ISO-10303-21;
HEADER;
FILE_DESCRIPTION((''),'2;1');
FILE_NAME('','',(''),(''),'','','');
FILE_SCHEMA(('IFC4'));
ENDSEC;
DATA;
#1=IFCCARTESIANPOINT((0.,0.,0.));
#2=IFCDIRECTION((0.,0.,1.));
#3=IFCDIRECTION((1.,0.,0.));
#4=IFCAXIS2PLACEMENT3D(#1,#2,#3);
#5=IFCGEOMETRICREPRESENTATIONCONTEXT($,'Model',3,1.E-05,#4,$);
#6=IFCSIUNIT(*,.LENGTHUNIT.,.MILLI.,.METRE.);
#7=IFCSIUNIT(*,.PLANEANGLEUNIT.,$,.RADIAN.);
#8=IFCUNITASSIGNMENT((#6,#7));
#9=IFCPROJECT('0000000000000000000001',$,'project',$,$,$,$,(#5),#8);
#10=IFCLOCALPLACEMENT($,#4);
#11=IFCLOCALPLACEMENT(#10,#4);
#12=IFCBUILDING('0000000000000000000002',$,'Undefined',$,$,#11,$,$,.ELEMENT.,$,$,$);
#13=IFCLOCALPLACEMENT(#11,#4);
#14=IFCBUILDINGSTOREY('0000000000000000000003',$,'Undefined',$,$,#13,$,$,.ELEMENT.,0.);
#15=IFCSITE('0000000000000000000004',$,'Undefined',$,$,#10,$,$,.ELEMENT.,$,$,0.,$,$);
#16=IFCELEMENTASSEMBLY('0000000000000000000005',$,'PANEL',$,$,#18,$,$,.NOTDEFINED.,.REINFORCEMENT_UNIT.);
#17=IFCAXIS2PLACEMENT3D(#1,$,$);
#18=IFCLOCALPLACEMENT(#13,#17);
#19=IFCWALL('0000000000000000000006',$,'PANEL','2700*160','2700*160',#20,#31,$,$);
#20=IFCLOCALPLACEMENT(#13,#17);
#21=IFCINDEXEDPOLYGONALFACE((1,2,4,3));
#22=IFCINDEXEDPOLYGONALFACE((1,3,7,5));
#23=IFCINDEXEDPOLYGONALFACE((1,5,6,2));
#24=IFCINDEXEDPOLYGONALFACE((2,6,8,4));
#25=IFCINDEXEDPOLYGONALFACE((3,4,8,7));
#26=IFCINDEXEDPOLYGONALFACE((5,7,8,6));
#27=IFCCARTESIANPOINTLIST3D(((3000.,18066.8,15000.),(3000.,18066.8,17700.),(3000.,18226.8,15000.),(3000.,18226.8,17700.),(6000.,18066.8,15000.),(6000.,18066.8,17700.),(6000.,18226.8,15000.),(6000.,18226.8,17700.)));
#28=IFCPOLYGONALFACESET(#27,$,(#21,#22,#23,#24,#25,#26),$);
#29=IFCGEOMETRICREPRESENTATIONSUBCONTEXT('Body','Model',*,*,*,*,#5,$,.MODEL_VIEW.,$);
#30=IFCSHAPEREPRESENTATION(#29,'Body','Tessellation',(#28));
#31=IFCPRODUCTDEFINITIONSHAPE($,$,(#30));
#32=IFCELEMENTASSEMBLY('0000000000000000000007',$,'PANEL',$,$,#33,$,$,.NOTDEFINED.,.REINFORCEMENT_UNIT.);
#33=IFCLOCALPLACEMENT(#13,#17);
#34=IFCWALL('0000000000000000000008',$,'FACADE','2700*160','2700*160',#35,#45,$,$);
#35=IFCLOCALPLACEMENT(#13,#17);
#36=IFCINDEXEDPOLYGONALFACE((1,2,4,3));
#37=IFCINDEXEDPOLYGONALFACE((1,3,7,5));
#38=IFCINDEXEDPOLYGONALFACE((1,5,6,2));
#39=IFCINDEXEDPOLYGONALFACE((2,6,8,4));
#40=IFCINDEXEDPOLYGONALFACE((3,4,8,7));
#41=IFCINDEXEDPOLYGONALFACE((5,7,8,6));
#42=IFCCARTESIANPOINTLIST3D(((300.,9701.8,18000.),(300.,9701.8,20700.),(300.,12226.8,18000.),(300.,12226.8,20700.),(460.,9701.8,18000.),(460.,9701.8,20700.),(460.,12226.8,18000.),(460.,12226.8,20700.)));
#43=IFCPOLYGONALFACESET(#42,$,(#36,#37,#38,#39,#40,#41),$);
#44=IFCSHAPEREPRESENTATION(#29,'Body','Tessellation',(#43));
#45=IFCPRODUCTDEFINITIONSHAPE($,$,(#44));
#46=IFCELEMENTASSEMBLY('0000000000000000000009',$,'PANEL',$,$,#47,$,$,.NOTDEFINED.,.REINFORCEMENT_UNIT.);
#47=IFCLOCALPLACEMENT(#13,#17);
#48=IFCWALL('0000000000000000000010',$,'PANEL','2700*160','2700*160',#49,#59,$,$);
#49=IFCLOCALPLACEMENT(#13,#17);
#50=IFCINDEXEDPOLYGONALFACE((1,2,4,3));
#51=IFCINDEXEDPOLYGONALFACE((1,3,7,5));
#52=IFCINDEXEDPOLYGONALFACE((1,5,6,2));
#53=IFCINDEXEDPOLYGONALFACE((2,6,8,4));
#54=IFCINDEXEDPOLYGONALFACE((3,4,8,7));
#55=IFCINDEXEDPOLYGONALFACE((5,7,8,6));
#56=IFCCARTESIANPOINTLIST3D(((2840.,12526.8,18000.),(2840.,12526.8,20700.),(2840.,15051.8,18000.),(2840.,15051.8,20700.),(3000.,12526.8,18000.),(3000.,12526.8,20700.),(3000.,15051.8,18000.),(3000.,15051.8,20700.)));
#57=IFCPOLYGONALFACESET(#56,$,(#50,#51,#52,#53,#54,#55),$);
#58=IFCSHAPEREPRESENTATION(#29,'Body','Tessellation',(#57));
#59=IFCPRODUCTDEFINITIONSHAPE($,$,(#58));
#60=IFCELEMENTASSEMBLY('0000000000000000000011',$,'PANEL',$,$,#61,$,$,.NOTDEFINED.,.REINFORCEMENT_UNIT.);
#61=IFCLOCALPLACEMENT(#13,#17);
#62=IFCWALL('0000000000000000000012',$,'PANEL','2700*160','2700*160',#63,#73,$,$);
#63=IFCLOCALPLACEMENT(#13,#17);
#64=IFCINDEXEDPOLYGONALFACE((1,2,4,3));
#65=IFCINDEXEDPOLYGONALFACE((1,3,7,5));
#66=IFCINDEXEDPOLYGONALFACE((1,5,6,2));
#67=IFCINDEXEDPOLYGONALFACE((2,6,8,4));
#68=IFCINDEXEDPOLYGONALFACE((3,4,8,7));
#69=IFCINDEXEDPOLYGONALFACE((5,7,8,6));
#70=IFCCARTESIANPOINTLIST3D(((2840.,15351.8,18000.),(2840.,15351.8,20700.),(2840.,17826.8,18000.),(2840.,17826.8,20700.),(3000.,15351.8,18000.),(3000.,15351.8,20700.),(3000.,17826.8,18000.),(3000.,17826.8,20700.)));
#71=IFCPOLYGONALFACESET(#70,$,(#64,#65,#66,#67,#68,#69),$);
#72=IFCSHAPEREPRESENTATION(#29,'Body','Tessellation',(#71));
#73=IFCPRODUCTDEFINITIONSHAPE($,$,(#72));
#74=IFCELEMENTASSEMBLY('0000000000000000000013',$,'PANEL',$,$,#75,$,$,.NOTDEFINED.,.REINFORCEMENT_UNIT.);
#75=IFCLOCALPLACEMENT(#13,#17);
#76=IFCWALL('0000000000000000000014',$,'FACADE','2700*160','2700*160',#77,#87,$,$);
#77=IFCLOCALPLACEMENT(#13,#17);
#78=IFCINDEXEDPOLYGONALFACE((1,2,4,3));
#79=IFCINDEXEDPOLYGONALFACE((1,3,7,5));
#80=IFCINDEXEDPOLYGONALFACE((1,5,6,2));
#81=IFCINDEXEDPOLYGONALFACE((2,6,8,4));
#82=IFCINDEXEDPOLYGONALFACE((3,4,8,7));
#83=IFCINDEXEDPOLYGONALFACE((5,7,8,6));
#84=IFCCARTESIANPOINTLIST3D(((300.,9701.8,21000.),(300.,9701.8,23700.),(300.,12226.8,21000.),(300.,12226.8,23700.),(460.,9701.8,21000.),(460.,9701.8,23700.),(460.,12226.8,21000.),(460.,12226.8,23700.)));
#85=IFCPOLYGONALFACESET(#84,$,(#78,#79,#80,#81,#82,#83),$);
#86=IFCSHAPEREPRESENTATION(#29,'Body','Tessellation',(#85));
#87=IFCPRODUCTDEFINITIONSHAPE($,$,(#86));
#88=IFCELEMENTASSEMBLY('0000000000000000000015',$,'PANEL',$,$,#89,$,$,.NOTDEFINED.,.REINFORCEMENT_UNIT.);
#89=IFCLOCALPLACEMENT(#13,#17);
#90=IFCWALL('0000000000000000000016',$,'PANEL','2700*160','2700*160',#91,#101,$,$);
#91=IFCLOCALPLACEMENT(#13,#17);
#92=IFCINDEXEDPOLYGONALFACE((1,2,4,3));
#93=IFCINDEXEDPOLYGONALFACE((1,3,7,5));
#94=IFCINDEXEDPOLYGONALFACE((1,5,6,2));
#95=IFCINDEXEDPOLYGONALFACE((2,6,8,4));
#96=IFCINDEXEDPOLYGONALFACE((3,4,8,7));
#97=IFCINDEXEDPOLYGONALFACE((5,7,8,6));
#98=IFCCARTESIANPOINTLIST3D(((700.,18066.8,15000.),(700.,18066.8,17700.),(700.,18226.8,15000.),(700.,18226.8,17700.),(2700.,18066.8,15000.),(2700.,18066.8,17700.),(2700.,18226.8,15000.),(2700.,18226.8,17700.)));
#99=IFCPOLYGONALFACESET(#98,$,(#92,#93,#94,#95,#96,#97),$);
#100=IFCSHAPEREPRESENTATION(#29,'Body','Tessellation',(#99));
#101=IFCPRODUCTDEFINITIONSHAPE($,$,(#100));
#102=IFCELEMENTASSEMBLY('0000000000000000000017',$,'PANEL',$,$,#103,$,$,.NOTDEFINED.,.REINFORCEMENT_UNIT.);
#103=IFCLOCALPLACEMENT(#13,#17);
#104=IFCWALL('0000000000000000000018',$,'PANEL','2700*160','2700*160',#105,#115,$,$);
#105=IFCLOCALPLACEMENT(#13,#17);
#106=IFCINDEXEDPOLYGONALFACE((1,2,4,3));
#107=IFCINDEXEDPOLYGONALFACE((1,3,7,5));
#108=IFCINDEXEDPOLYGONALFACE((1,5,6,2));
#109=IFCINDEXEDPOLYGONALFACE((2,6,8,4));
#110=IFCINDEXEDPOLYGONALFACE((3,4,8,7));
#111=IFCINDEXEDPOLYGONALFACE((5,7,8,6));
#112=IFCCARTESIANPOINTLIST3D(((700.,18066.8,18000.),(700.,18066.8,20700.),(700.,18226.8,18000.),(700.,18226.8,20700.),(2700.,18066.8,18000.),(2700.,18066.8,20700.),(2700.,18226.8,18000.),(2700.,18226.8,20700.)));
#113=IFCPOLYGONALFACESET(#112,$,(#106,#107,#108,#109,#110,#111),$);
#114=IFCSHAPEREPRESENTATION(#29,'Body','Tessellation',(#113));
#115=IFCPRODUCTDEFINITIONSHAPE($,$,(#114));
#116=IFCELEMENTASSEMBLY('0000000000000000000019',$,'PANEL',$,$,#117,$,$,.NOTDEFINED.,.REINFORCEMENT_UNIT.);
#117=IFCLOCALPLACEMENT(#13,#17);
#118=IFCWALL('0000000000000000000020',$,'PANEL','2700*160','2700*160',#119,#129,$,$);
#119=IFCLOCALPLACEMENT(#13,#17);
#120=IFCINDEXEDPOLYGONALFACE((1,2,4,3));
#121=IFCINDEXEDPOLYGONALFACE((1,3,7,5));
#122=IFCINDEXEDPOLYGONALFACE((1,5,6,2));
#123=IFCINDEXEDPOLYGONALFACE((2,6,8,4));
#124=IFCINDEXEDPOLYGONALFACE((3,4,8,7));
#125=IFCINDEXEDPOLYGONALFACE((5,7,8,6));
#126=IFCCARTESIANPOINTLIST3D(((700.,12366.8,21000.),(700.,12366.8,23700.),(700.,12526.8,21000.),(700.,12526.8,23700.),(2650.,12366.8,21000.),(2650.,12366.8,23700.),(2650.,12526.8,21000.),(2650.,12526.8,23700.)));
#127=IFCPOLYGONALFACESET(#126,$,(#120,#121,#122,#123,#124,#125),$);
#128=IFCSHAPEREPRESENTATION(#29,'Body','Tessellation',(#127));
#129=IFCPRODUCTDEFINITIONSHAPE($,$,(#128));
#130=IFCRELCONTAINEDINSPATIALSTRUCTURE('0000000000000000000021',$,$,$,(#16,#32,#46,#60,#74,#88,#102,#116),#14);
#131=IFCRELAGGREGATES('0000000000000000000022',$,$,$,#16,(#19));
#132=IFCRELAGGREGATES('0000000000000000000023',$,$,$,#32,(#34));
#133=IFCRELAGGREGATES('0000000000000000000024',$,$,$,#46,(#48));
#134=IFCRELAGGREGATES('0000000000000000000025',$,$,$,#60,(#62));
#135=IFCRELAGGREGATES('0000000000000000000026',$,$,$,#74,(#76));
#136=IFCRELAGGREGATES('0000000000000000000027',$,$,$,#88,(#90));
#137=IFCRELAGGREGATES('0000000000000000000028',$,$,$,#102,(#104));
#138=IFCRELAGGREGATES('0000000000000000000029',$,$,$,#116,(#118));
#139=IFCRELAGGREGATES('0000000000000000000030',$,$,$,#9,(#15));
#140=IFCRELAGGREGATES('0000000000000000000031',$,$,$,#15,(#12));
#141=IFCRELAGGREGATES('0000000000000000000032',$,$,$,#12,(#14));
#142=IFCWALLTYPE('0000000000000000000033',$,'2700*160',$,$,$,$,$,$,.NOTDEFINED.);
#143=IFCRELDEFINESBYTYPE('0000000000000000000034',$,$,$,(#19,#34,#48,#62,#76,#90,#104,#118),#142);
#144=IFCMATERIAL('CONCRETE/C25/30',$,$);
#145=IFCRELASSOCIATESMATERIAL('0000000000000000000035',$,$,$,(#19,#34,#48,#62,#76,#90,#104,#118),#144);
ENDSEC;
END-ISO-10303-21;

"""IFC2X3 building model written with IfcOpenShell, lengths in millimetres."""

from ifc_helpers import new_model, si_unit, frame, frame_2d, origin_with_axes, place, context, subcontext, project, spatial, rectangle, extrude, material, type_object, element, aggregate, save


model = new_model("IFC2X3")

# Units and contexts
model_context = context("Model", 3, precision=1e-05, world=origin_with_axes())
body_context = subcontext(model_context, "Body", "Model", "MODEL_VIEW")
ifc_project = project(units=[si_unit("LENGTHUNIT", "METRE", prefix="MILLI"), si_unit("PLANEANGLEUNIT", "RADIAN")], contexts=[model_context])

# Site, building, storey
site_placement = place(None, origin_with_axes())
site = spatial("IfcSite", under=ifc_project, at=site_placement, Name="Undefined", CompositionType="ELEMENT", RefElevation=0.0)
building_placement = place(site_placement, origin_with_axes())
building = spatial("IfcBuilding", under=site, at=building_placement, Name="Undefined", CompositionType="ELEMENT")
storey_placement = place(building_placement, origin_with_axes())
storey = spatial("IfcBuildingStorey", under=building, at=storey_placement, Name="Undefined", CompositionType="ELEMENT", Elevation=0.0)

# Shared definitions
ifc_material = material(Name="CONCRETE/C25/30")

# Element assemblies, walls
assembly_1_placement = place(storey_placement, origin_with_axes())
assembly_1 = element("IfcElementAssembly", 1, at=assembly_1_placement, inside=storey, Name="PANEL", AssemblyPlace="NOTDEFINED", PredefinedType="REINFORCEMENT_UNIT")
wall_type = type_object("IfcWallType", Name="2700*160", PredefinedType="NOTDEFINED")
wall_1_placement = place(assembly_1_placement, frame((3000.0, 18146.8, 15000.0), z_axis=(0.0, 0.0, 1.0), x_axis=(1.0, 0.0, 0.0)))
wall_1 = element("IfcWall", 2, at=wall_1_placement, type_object=wall_type, material=ifc_material, Name="PANEL", Description="2700*160", ObjectType="2700*160", context=body_context, shape_type="SweptSolid", body=[
    extrude(rectangle(XDim=3000.0, YDim=160.0, at=frame_2d((0.0, 1500.0), x_axis=(0.0, -1.0))), frame((0.0, 0.0, 0.0), z_axis=(0.0, 0.0, 1.0), x_axis=(0.0, -1.0, 0.0)), (0.0, 0.0, 1.0), 2700.0),
])
aggregate(assembly_1, [wall_1])
assembly_2_placement = place(storey_placement, origin_with_axes())
assembly_2 = element("IfcElementAssembly", 3, at=assembly_2_placement, inside=storey, Name="PANEL", AssemblyPlace="NOTDEFINED", PredefinedType="REINFORCEMENT_UNIT")
wall_2_placement = place(assembly_2_placement, frame((380.0, 12226.8, 18000.0), z_axis=(0.0, 0.0, 1.0), x_axis=(0.0, -1.0, 0.0)))
wall_2 = element("IfcWall", 4, at=wall_2_placement, type_object=wall_type, material=ifc_material, Name="FACADE", Description="2700*160", ObjectType="2700*160", context=body_context, shape_type="SweptSolid", body=[
    extrude(rectangle(XDim=2525.0, YDim=160.0, at=frame_2d((0.0, 1262.5), x_axis=(0.0, -1.0))), frame((0.0, 0.0, 0.0), z_axis=(0.0, 0.0, 1.0), x_axis=(0.0, -1.0, 0.0)), (0.0, 0.0, 1.0), 2700.0),
])
aggregate(assembly_2, [wall_2])
assembly_3_placement = place(storey_placement, origin_with_axes())
assembly_3 = element("IfcElementAssembly", 5, at=assembly_3_placement, inside=storey, Name="PANEL", AssemblyPlace="NOTDEFINED", PredefinedType="REINFORCEMENT_UNIT")
wall_3_placement = place(assembly_3_placement, frame((2920.0, 12526.8, 18000.0), z_axis=(0.0, 0.0, 1.0), x_axis=(0.0, 1.0, 0.0)))
wall_3 = element("IfcWall", 6, at=wall_3_placement, type_object=wall_type, material=ifc_material, Name="PANEL", Description="2700*160", ObjectType="2700*160", context=body_context, shape_type="SweptSolid", body=[
    extrude(rectangle(XDim=2525.0, YDim=160.0, at=frame_2d((0.0, 1262.5), x_axis=(0.0, -1.0))), frame((0.0, 0.0, 0.0), z_axis=(0.0, 0.0, 1.0), x_axis=(0.0, -1.0, 0.0)), (0.0, 0.0, 1.0), 2700.0),
])
aggregate(assembly_3, [wall_3])
assembly_4_placement = place(storey_placement, origin_with_axes())
assembly_4 = element("IfcElementAssembly", 7, at=assembly_4_placement, inside=storey, Name="PANEL", AssemblyPlace="NOTDEFINED", PredefinedType="REINFORCEMENT_UNIT")
wall_4_placement = place(assembly_4_placement, frame((2920.0, 15351.8, 18000.0), z_axis=(0.0, 0.0, 1.0), x_axis=(0.0, 1.0, 0.0)))
wall_4 = element("IfcWall", 8, at=wall_4_placement, type_object=wall_type, material=ifc_material, Name="PANEL", Description="2700*160", ObjectType="2700*160", context=body_context, shape_type="SweptSolid", body=[
    extrude(rectangle(XDim=2475.0, YDim=160.0, at=frame_2d((0.0, 1237.5), x_axis=(0.0, -1.0))), frame((0.0, 0.0, 0.0), z_axis=(0.0, 0.0, 1.0), x_axis=(0.0, -1.0, 0.0)), (0.0, 0.0, 1.0), 2700.0),
])
aggregate(assembly_4, [wall_4])
assembly_5_placement = place(storey_placement, origin_with_axes())
assembly_5 = element("IfcElementAssembly", 9, at=assembly_5_placement, inside=storey, Name="PANEL", AssemblyPlace="NOTDEFINED", PredefinedType="REINFORCEMENT_UNIT")
wall_5_placement = place(assembly_5_placement, frame((380.0, 12226.8, 21000.0), z_axis=(0.0, 0.0, 1.0), x_axis=(0.0, -1.0, 0.0)))
wall_5 = element("IfcWall", 10, at=wall_5_placement, type_object=wall_type, material=ifc_material, Name="FACADE", Description="2700*160", ObjectType="2700*160", context=body_context, shape_type="SweptSolid", body=[
    extrude(rectangle(XDim=2525.0, YDim=160.0, at=frame_2d((0.0, 1262.5), x_axis=(0.0, -1.0))), frame((0.0, 0.0, 0.0), z_axis=(0.0, 0.0, 1.0), x_axis=(0.0, -1.0, 0.0)), (0.0, 0.0, 1.0), 2700.0),
])
aggregate(assembly_5, [wall_5])
assembly_6_placement = place(storey_placement, origin_with_axes())
assembly_6 = element("IfcElementAssembly", 11, at=assembly_6_placement, inside=storey, Name="PANEL", AssemblyPlace="NOTDEFINED", PredefinedType="REINFORCEMENT_UNIT")
wall_6_placement = place(assembly_6_placement, frame((2700.0, 18146.8, 15000.0), z_axis=(0.0, 0.0, 1.0), x_axis=(-1.0, 0.0, 0.0)))
wall_6 = element("IfcWall", 12, at=wall_6_placement, type_object=wall_type, material=ifc_material, Name="PANEL", Description="2700*160", ObjectType="2700*160", context=body_context, shape_type="SweptSolid", body=[
    extrude(rectangle(XDim=2000.0, YDim=160.0, at=frame_2d((0.0, 1000.0), x_axis=(0.0, -1.0))), frame((0.0, 0.0, 0.0), z_axis=(0.0, 0.0, 1.0), x_axis=(0.0, -1.0, 0.0)), (0.0, 0.0, 1.0), 2700.0),
])
aggregate(assembly_6, [wall_6])
assembly_7_placement = place(storey_placement, origin_with_axes())
assembly_7 = element("IfcElementAssembly", 13, at=assembly_7_placement, inside=storey, Name="PANEL", AssemblyPlace="NOTDEFINED", PredefinedType="REINFORCEMENT_UNIT")
wall_7_placement = place(assembly_7_placement, frame((2700.0, 18146.8, 18000.0), z_axis=(0.0, 0.0, 1.0), x_axis=(-1.0, 0.0, 0.0)))
wall_7 = element("IfcWall", 14, at=wall_7_placement, type_object=wall_type, material=ifc_material, Name="PANEL", Description="2700*160", ObjectType="2700*160", context=body_context, shape_type="SweptSolid", body=[
    extrude(rectangle(XDim=2000.0, YDim=160.0, at=frame_2d((0.0, 1000.0), x_axis=(0.0, -1.0))), frame((0.0, 0.0, 0.0), z_axis=(0.0, 0.0, 1.0), x_axis=(0.0, -1.0, 0.0)), (0.0, 0.0, 1.0), 2700.0),
])
aggregate(assembly_7, [wall_7])
assembly_8_placement = place(storey_placement, origin_with_axes())
assembly_8 = element("IfcElementAssembly", 15, at=assembly_8_placement, inside=storey, Name="PANEL", AssemblyPlace="NOTDEFINED", PredefinedType="REINFORCEMENT_UNIT")
wall_8_placement = place(assembly_8_placement, frame((2650.0, 12446.8, 21000.0), z_axis=(0.0, 0.0, 1.0), x_axis=(-1.0, 0.0, 0.0)))
wall_8 = element("IfcWall", 16, at=wall_8_placement, type_object=wall_type, material=ifc_material, Name="PANEL", Description="2700*160", ObjectType="2700*160", context=body_context, shape_type="SweptSolid", body=[
    extrude(rectangle(XDim=1950.0, YDim=160.0, at=frame_2d((0.0, 975.0), x_axis=(0.0, -1.0))), frame((0.0, 0.0, 0.0), z_axis=(0.0, 0.0, 1.0), x_axis=(0.0, -1.0, 0.0)), (0.0, 0.0, 1.0), 2700.0),
])
aggregate(assembly_8, [wall_8])

save(model, "model.ifc")
